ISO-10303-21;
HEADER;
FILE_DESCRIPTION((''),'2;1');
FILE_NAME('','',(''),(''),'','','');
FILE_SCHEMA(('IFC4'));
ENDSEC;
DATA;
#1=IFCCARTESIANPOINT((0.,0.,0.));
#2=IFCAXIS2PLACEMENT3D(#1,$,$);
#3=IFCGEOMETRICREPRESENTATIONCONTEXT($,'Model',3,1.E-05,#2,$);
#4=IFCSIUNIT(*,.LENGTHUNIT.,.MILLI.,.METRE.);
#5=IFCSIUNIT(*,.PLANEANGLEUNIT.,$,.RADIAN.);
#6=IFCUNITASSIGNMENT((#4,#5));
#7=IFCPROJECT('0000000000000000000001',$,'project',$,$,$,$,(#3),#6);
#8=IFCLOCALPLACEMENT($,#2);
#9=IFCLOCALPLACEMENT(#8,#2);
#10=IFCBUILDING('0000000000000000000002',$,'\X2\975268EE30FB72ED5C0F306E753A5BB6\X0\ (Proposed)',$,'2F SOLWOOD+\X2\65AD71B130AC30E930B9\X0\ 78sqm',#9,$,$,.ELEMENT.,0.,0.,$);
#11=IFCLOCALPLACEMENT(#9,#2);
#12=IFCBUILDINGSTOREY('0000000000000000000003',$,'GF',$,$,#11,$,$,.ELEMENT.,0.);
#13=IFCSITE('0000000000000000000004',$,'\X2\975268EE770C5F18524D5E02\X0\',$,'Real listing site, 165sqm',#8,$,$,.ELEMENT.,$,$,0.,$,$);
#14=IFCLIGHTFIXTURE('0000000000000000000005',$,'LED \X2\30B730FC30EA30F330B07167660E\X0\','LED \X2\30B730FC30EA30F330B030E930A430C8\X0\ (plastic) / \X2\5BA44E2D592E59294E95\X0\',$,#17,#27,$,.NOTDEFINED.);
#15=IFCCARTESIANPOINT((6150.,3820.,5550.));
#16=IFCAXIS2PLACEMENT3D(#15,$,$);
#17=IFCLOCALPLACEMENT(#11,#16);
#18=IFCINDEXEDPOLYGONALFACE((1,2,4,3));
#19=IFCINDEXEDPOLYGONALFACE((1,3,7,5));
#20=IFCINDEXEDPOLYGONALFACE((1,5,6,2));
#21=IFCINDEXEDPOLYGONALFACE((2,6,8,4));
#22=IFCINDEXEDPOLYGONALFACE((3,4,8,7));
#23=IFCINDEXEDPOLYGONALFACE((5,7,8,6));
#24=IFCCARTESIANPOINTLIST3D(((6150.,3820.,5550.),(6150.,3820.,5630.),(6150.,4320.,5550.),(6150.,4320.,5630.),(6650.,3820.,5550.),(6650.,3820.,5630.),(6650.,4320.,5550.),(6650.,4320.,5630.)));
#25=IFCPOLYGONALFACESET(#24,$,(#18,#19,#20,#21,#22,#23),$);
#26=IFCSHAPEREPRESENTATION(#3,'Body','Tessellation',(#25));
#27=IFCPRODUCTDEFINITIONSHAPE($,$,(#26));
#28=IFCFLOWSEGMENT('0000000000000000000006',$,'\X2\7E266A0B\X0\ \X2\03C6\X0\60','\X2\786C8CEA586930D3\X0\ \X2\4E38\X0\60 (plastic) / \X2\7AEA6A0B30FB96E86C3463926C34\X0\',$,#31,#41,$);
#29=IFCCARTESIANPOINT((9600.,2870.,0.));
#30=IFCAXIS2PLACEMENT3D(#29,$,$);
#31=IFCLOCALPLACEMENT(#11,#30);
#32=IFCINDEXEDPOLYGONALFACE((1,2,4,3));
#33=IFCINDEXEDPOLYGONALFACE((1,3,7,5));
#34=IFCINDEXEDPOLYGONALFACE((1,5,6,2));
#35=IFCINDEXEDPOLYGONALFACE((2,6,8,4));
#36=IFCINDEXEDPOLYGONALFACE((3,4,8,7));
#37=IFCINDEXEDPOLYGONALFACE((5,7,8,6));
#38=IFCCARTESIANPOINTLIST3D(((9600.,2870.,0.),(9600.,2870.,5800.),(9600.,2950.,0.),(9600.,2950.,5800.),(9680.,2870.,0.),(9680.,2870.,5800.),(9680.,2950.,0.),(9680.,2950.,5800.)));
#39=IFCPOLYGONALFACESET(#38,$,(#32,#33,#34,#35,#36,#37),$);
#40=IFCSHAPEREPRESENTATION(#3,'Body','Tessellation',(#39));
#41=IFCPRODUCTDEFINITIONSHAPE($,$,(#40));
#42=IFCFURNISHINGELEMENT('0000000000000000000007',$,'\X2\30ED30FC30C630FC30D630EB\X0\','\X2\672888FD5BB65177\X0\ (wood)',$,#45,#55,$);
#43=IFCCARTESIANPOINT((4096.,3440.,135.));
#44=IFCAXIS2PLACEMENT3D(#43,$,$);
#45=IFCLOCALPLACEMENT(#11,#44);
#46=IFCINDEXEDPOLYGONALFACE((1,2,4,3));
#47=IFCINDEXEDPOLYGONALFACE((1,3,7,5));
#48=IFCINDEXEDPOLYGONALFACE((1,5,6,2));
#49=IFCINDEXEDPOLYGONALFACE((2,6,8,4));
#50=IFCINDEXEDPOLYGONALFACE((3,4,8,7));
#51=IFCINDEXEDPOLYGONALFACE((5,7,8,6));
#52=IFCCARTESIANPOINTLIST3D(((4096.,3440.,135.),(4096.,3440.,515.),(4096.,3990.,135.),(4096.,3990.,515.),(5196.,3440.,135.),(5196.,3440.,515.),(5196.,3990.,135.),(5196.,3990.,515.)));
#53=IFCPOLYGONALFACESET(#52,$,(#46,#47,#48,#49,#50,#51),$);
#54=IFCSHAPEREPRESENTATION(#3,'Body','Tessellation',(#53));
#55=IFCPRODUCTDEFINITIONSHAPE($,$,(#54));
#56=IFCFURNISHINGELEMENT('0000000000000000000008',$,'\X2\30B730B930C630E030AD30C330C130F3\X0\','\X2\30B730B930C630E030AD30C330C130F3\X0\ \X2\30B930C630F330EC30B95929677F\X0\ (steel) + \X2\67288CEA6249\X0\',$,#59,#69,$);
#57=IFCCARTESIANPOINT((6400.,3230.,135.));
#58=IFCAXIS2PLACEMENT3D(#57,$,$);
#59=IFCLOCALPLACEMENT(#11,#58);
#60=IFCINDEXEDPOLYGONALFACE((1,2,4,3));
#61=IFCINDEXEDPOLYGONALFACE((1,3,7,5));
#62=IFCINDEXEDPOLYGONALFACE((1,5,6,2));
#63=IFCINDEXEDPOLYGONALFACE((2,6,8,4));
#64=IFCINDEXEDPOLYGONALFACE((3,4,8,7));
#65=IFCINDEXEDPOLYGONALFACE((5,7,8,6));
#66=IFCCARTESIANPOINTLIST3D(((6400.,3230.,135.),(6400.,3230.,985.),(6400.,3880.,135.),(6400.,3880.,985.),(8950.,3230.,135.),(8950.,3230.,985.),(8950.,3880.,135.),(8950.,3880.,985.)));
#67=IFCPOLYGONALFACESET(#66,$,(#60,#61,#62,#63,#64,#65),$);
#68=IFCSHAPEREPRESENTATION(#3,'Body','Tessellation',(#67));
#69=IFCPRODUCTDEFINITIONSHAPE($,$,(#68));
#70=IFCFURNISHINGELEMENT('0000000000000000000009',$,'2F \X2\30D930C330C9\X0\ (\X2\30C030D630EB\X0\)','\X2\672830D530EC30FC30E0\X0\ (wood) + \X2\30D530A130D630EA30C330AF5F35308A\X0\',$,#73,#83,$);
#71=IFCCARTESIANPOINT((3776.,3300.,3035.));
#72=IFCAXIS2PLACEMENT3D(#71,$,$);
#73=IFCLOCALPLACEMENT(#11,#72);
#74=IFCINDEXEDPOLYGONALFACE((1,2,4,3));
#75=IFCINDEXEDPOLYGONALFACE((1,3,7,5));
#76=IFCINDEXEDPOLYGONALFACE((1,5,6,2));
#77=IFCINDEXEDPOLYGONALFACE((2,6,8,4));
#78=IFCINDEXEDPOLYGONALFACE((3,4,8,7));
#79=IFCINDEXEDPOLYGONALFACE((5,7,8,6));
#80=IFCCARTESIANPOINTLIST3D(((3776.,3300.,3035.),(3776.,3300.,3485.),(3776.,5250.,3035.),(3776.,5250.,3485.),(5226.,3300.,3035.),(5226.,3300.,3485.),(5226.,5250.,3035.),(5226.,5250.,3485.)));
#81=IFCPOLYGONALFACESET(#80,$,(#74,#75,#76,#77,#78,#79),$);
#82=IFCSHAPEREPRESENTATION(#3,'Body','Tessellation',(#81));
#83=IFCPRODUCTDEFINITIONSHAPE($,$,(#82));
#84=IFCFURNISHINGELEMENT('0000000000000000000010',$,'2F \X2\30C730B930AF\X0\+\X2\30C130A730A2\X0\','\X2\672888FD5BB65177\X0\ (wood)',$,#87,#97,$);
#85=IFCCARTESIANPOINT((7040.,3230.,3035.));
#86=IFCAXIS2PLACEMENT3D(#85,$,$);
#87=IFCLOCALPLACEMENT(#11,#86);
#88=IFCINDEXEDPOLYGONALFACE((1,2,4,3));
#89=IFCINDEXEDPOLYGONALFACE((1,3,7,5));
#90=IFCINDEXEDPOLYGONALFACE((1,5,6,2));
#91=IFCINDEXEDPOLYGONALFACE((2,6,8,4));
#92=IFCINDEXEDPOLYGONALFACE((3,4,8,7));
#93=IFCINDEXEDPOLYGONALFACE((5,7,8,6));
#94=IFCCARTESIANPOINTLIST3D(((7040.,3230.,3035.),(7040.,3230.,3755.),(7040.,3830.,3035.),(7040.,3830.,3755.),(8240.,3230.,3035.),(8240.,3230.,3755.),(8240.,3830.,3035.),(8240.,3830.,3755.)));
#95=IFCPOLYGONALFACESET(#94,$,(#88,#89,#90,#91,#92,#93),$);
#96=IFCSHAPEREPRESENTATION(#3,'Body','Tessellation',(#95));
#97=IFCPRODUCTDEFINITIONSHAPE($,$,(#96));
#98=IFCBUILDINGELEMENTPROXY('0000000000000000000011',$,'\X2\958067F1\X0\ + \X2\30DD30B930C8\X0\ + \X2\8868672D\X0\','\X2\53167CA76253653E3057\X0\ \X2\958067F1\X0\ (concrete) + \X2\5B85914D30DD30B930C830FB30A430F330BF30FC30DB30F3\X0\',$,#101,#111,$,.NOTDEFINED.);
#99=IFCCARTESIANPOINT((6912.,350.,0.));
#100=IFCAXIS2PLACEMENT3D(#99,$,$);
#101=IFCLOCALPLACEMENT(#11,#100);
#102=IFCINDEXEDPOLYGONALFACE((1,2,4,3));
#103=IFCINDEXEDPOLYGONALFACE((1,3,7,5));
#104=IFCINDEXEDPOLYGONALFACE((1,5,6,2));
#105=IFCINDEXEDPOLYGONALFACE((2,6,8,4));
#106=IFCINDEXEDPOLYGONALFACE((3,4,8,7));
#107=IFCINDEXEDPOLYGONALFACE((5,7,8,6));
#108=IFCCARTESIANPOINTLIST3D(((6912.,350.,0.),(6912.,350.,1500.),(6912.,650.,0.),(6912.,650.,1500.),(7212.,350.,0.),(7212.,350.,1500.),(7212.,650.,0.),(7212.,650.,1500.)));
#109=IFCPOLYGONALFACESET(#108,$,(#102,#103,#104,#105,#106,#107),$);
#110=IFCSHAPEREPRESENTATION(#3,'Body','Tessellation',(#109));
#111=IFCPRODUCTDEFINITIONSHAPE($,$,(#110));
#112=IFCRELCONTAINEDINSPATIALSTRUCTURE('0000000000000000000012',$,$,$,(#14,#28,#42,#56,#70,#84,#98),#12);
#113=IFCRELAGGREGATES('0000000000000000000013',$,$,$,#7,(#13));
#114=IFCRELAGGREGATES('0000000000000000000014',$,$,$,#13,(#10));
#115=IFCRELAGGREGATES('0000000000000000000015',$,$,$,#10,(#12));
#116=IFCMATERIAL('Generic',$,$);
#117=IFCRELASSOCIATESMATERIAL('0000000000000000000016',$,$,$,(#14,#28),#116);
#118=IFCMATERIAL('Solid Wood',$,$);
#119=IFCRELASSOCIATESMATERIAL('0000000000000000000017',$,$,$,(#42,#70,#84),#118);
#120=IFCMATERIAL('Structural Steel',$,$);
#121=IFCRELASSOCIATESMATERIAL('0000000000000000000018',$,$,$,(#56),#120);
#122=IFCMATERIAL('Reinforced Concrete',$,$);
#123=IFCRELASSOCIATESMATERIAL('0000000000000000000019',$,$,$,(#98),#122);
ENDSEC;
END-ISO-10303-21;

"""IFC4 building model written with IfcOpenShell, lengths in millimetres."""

from ifc_helpers import new_model, si_unit, frame, frame_2d, origin, place, context, project, spatial, rectangle, extrude, material, element, save


model = new_model("IFC4")

# Units and contexts
model_context = context("Model", 3, precision=1e-05, world=origin())
ifc_project = project(units=[si_unit("LENGTHUNIT", "METRE", prefix="MILLI"), si_unit("PLANEANGLEUNIT", "RADIAN")], contexts=[model_context])

# Site, building, storey
site_placement = place(None, origin())
site = spatial("IfcSite", under=ifc_project, at=site_placement, Name="青森県弘前市", ObjectType="Real listing site, 165sqm", CompositionType="ELEMENT", RefElevation=0.0)
building_placement = place(site_placement, origin())
building = spatial("IfcBuilding", under=site, at=building_placement, Name="青森・狭小の町家 (Proposed)", ObjectType="2F SOLWOOD+断熱ガラス 78sqm", CompositionType="ELEMENT", ElevationOfRefHeight=0.0, ElevationOfTerrain=0.0)
storey_placement = place(building_placement, origin())
storey = spatial("IfcBuildingStorey", under=building, at=storey_placement, Name="GF", CompositionType="ELEMENT", Elevation=0.0)

# Shared definitions
ifc_material_1 = material(Name="Solid Wood")

# Shared definitions
ifc_material_2 = material(Name="Reinforced Concrete")

# Shared definitions
ifc_material_3 = material(Name="Structural Steel")

# Shared definitions
ifc_material_4 = material(Name="Generic")

# Light fixture
light_fixture_1_placement = place(storey_placement, frame((6150.0, 3820.0, 5550.0)))
element("IfcLightFixture", 1, at=light_fixture_1_placement, inside=storey, material=ifc_material_4, Name="LED シーリング照明", Description="LED シーリングライト (plastic) / 室中央天井", PredefinedType="NOTDEFINED", context=model_context, shape_type="SweptSolid", body=[
    extrude(rectangle(XDim=500.0, YDim=500.0, at=frame_2d((250.0, 250.0))), frame((6150.0, 3820.0, 5550.0)), (0.0, 0.0, 1.0), 80.0),
])

# Flow segment
flow_segment_placement = place(storey_placement, frame((9600.0, 2870.0, 0.0)))
element("IfcFlowSegment", 2, at=flow_segment_placement, inside=storey, material=ifc_material_4, Name="縦樋 φ60", Description="硬質塩ビ 丸60 (plastic) / 竪樋・雨水排水", context=model_context, shape_type="SweptSolid", body=[
    extrude(rectangle(XDim=80.0, YDim=80.0, at=frame_2d((40.0, 40.0))), frame((9600.0, 2870.0, 0.0)), (0.0, 0.0, 1.0), 5800.0),
])

# Furnishing elements
furnishing_1_placement = place(storey_placement, frame((4096.0, 3440.0, 135.0)))
element("IfcFurnishingElement", 3, at=furnishing_1_placement, inside=storey, material=ifc_material_1, Name="ローテーブル", Description="木製家具 (wood)", context=model_context, shape_type="SweptSolid", body=[
    extrude(rectangle(XDim=1100.0, YDim=550.0, at=frame_2d((550.0, 275.0))), frame((4096.0, 3440.0, 135.0)), (0.0, 0.0, 1.0), 380.0),
])
furnishing_2_placement = place(storey_placement, frame((6400.0, 3230.0, 135.0)))
element("IfcFurnishingElement", 4, at=furnishing_2_placement, inside=storey, material=ifc_material_3, Name="システムキッチン", Description="システムキッチン ステンレス天板 (steel) + 木質扉", context=model_context, shape_type="SweptSolid", body=[
    extrude(rectangle(XDim=2550.0, YDim=650.0, at=frame_2d((1275.0, 325.0))), frame((6400.0, 3230.0, 135.0)), (0.0, 0.0, 1.0), 850.0),
])
furnishing_3_placement = place(storey_placement, frame((3776.0, 3300.0, 3035.0)))
element("IfcFurnishingElement", 5, at=furnishing_3_placement, inside=storey, material=ifc_material_1, Name="2F ベッド (ダブル)", Description="木フレーム (wood) + ファブリック張り", context=model_context, shape_type="SweptSolid", body=[
    extrude(rectangle(XDim=1450.0, YDim=1950.0, at=frame_2d((725.0, 975.0))), frame((3776.0, 3300.0, 3035.0)), (0.0, 0.0, 1.0), 450.0),
])
furnishing_4_placement = place(storey_placement, frame((7040.0, 3230.0, 3035.0)))
element("IfcFurnishingElement", 6, at=furnishing_4_placement, inside=storey, material=ifc_material_1, Name="2F デスク+チェア", Description="木製家具 (wood)", context=model_context, shape_type="SweptSolid", body=[
    extrude(rectangle(XDim=1200.0, YDim=600.0, at=frame_2d((600.0, 300.0))), frame((7040.0, 3230.0, 3035.0)), (0.0, 0.0, 1.0), 720.0),
])

# Building element proxy
proxy_placement = place(storey_placement, frame((6912.0, 350.0, 0.0)))
element("IfcBuildingElementProxy", 7, at=proxy_placement, inside=storey, material=ifc_material_2, Name="門柱 + ポスト + 表札", Description="化粧打放し 門柱 (concrete) + 宅配ポスト・インターホン", PredefinedType="NOTDEFINED", context=model_context, shape_type="SweptSolid", body=[
    extrude(rectangle(XDim=300.0, YDim=300.0, at=frame_2d((150.0, 150.0))), frame((6912.0, 350.0, 0.0)), (0.0, 0.0, 1.0), 1500.0),
])

save(model, "model.ifc")
